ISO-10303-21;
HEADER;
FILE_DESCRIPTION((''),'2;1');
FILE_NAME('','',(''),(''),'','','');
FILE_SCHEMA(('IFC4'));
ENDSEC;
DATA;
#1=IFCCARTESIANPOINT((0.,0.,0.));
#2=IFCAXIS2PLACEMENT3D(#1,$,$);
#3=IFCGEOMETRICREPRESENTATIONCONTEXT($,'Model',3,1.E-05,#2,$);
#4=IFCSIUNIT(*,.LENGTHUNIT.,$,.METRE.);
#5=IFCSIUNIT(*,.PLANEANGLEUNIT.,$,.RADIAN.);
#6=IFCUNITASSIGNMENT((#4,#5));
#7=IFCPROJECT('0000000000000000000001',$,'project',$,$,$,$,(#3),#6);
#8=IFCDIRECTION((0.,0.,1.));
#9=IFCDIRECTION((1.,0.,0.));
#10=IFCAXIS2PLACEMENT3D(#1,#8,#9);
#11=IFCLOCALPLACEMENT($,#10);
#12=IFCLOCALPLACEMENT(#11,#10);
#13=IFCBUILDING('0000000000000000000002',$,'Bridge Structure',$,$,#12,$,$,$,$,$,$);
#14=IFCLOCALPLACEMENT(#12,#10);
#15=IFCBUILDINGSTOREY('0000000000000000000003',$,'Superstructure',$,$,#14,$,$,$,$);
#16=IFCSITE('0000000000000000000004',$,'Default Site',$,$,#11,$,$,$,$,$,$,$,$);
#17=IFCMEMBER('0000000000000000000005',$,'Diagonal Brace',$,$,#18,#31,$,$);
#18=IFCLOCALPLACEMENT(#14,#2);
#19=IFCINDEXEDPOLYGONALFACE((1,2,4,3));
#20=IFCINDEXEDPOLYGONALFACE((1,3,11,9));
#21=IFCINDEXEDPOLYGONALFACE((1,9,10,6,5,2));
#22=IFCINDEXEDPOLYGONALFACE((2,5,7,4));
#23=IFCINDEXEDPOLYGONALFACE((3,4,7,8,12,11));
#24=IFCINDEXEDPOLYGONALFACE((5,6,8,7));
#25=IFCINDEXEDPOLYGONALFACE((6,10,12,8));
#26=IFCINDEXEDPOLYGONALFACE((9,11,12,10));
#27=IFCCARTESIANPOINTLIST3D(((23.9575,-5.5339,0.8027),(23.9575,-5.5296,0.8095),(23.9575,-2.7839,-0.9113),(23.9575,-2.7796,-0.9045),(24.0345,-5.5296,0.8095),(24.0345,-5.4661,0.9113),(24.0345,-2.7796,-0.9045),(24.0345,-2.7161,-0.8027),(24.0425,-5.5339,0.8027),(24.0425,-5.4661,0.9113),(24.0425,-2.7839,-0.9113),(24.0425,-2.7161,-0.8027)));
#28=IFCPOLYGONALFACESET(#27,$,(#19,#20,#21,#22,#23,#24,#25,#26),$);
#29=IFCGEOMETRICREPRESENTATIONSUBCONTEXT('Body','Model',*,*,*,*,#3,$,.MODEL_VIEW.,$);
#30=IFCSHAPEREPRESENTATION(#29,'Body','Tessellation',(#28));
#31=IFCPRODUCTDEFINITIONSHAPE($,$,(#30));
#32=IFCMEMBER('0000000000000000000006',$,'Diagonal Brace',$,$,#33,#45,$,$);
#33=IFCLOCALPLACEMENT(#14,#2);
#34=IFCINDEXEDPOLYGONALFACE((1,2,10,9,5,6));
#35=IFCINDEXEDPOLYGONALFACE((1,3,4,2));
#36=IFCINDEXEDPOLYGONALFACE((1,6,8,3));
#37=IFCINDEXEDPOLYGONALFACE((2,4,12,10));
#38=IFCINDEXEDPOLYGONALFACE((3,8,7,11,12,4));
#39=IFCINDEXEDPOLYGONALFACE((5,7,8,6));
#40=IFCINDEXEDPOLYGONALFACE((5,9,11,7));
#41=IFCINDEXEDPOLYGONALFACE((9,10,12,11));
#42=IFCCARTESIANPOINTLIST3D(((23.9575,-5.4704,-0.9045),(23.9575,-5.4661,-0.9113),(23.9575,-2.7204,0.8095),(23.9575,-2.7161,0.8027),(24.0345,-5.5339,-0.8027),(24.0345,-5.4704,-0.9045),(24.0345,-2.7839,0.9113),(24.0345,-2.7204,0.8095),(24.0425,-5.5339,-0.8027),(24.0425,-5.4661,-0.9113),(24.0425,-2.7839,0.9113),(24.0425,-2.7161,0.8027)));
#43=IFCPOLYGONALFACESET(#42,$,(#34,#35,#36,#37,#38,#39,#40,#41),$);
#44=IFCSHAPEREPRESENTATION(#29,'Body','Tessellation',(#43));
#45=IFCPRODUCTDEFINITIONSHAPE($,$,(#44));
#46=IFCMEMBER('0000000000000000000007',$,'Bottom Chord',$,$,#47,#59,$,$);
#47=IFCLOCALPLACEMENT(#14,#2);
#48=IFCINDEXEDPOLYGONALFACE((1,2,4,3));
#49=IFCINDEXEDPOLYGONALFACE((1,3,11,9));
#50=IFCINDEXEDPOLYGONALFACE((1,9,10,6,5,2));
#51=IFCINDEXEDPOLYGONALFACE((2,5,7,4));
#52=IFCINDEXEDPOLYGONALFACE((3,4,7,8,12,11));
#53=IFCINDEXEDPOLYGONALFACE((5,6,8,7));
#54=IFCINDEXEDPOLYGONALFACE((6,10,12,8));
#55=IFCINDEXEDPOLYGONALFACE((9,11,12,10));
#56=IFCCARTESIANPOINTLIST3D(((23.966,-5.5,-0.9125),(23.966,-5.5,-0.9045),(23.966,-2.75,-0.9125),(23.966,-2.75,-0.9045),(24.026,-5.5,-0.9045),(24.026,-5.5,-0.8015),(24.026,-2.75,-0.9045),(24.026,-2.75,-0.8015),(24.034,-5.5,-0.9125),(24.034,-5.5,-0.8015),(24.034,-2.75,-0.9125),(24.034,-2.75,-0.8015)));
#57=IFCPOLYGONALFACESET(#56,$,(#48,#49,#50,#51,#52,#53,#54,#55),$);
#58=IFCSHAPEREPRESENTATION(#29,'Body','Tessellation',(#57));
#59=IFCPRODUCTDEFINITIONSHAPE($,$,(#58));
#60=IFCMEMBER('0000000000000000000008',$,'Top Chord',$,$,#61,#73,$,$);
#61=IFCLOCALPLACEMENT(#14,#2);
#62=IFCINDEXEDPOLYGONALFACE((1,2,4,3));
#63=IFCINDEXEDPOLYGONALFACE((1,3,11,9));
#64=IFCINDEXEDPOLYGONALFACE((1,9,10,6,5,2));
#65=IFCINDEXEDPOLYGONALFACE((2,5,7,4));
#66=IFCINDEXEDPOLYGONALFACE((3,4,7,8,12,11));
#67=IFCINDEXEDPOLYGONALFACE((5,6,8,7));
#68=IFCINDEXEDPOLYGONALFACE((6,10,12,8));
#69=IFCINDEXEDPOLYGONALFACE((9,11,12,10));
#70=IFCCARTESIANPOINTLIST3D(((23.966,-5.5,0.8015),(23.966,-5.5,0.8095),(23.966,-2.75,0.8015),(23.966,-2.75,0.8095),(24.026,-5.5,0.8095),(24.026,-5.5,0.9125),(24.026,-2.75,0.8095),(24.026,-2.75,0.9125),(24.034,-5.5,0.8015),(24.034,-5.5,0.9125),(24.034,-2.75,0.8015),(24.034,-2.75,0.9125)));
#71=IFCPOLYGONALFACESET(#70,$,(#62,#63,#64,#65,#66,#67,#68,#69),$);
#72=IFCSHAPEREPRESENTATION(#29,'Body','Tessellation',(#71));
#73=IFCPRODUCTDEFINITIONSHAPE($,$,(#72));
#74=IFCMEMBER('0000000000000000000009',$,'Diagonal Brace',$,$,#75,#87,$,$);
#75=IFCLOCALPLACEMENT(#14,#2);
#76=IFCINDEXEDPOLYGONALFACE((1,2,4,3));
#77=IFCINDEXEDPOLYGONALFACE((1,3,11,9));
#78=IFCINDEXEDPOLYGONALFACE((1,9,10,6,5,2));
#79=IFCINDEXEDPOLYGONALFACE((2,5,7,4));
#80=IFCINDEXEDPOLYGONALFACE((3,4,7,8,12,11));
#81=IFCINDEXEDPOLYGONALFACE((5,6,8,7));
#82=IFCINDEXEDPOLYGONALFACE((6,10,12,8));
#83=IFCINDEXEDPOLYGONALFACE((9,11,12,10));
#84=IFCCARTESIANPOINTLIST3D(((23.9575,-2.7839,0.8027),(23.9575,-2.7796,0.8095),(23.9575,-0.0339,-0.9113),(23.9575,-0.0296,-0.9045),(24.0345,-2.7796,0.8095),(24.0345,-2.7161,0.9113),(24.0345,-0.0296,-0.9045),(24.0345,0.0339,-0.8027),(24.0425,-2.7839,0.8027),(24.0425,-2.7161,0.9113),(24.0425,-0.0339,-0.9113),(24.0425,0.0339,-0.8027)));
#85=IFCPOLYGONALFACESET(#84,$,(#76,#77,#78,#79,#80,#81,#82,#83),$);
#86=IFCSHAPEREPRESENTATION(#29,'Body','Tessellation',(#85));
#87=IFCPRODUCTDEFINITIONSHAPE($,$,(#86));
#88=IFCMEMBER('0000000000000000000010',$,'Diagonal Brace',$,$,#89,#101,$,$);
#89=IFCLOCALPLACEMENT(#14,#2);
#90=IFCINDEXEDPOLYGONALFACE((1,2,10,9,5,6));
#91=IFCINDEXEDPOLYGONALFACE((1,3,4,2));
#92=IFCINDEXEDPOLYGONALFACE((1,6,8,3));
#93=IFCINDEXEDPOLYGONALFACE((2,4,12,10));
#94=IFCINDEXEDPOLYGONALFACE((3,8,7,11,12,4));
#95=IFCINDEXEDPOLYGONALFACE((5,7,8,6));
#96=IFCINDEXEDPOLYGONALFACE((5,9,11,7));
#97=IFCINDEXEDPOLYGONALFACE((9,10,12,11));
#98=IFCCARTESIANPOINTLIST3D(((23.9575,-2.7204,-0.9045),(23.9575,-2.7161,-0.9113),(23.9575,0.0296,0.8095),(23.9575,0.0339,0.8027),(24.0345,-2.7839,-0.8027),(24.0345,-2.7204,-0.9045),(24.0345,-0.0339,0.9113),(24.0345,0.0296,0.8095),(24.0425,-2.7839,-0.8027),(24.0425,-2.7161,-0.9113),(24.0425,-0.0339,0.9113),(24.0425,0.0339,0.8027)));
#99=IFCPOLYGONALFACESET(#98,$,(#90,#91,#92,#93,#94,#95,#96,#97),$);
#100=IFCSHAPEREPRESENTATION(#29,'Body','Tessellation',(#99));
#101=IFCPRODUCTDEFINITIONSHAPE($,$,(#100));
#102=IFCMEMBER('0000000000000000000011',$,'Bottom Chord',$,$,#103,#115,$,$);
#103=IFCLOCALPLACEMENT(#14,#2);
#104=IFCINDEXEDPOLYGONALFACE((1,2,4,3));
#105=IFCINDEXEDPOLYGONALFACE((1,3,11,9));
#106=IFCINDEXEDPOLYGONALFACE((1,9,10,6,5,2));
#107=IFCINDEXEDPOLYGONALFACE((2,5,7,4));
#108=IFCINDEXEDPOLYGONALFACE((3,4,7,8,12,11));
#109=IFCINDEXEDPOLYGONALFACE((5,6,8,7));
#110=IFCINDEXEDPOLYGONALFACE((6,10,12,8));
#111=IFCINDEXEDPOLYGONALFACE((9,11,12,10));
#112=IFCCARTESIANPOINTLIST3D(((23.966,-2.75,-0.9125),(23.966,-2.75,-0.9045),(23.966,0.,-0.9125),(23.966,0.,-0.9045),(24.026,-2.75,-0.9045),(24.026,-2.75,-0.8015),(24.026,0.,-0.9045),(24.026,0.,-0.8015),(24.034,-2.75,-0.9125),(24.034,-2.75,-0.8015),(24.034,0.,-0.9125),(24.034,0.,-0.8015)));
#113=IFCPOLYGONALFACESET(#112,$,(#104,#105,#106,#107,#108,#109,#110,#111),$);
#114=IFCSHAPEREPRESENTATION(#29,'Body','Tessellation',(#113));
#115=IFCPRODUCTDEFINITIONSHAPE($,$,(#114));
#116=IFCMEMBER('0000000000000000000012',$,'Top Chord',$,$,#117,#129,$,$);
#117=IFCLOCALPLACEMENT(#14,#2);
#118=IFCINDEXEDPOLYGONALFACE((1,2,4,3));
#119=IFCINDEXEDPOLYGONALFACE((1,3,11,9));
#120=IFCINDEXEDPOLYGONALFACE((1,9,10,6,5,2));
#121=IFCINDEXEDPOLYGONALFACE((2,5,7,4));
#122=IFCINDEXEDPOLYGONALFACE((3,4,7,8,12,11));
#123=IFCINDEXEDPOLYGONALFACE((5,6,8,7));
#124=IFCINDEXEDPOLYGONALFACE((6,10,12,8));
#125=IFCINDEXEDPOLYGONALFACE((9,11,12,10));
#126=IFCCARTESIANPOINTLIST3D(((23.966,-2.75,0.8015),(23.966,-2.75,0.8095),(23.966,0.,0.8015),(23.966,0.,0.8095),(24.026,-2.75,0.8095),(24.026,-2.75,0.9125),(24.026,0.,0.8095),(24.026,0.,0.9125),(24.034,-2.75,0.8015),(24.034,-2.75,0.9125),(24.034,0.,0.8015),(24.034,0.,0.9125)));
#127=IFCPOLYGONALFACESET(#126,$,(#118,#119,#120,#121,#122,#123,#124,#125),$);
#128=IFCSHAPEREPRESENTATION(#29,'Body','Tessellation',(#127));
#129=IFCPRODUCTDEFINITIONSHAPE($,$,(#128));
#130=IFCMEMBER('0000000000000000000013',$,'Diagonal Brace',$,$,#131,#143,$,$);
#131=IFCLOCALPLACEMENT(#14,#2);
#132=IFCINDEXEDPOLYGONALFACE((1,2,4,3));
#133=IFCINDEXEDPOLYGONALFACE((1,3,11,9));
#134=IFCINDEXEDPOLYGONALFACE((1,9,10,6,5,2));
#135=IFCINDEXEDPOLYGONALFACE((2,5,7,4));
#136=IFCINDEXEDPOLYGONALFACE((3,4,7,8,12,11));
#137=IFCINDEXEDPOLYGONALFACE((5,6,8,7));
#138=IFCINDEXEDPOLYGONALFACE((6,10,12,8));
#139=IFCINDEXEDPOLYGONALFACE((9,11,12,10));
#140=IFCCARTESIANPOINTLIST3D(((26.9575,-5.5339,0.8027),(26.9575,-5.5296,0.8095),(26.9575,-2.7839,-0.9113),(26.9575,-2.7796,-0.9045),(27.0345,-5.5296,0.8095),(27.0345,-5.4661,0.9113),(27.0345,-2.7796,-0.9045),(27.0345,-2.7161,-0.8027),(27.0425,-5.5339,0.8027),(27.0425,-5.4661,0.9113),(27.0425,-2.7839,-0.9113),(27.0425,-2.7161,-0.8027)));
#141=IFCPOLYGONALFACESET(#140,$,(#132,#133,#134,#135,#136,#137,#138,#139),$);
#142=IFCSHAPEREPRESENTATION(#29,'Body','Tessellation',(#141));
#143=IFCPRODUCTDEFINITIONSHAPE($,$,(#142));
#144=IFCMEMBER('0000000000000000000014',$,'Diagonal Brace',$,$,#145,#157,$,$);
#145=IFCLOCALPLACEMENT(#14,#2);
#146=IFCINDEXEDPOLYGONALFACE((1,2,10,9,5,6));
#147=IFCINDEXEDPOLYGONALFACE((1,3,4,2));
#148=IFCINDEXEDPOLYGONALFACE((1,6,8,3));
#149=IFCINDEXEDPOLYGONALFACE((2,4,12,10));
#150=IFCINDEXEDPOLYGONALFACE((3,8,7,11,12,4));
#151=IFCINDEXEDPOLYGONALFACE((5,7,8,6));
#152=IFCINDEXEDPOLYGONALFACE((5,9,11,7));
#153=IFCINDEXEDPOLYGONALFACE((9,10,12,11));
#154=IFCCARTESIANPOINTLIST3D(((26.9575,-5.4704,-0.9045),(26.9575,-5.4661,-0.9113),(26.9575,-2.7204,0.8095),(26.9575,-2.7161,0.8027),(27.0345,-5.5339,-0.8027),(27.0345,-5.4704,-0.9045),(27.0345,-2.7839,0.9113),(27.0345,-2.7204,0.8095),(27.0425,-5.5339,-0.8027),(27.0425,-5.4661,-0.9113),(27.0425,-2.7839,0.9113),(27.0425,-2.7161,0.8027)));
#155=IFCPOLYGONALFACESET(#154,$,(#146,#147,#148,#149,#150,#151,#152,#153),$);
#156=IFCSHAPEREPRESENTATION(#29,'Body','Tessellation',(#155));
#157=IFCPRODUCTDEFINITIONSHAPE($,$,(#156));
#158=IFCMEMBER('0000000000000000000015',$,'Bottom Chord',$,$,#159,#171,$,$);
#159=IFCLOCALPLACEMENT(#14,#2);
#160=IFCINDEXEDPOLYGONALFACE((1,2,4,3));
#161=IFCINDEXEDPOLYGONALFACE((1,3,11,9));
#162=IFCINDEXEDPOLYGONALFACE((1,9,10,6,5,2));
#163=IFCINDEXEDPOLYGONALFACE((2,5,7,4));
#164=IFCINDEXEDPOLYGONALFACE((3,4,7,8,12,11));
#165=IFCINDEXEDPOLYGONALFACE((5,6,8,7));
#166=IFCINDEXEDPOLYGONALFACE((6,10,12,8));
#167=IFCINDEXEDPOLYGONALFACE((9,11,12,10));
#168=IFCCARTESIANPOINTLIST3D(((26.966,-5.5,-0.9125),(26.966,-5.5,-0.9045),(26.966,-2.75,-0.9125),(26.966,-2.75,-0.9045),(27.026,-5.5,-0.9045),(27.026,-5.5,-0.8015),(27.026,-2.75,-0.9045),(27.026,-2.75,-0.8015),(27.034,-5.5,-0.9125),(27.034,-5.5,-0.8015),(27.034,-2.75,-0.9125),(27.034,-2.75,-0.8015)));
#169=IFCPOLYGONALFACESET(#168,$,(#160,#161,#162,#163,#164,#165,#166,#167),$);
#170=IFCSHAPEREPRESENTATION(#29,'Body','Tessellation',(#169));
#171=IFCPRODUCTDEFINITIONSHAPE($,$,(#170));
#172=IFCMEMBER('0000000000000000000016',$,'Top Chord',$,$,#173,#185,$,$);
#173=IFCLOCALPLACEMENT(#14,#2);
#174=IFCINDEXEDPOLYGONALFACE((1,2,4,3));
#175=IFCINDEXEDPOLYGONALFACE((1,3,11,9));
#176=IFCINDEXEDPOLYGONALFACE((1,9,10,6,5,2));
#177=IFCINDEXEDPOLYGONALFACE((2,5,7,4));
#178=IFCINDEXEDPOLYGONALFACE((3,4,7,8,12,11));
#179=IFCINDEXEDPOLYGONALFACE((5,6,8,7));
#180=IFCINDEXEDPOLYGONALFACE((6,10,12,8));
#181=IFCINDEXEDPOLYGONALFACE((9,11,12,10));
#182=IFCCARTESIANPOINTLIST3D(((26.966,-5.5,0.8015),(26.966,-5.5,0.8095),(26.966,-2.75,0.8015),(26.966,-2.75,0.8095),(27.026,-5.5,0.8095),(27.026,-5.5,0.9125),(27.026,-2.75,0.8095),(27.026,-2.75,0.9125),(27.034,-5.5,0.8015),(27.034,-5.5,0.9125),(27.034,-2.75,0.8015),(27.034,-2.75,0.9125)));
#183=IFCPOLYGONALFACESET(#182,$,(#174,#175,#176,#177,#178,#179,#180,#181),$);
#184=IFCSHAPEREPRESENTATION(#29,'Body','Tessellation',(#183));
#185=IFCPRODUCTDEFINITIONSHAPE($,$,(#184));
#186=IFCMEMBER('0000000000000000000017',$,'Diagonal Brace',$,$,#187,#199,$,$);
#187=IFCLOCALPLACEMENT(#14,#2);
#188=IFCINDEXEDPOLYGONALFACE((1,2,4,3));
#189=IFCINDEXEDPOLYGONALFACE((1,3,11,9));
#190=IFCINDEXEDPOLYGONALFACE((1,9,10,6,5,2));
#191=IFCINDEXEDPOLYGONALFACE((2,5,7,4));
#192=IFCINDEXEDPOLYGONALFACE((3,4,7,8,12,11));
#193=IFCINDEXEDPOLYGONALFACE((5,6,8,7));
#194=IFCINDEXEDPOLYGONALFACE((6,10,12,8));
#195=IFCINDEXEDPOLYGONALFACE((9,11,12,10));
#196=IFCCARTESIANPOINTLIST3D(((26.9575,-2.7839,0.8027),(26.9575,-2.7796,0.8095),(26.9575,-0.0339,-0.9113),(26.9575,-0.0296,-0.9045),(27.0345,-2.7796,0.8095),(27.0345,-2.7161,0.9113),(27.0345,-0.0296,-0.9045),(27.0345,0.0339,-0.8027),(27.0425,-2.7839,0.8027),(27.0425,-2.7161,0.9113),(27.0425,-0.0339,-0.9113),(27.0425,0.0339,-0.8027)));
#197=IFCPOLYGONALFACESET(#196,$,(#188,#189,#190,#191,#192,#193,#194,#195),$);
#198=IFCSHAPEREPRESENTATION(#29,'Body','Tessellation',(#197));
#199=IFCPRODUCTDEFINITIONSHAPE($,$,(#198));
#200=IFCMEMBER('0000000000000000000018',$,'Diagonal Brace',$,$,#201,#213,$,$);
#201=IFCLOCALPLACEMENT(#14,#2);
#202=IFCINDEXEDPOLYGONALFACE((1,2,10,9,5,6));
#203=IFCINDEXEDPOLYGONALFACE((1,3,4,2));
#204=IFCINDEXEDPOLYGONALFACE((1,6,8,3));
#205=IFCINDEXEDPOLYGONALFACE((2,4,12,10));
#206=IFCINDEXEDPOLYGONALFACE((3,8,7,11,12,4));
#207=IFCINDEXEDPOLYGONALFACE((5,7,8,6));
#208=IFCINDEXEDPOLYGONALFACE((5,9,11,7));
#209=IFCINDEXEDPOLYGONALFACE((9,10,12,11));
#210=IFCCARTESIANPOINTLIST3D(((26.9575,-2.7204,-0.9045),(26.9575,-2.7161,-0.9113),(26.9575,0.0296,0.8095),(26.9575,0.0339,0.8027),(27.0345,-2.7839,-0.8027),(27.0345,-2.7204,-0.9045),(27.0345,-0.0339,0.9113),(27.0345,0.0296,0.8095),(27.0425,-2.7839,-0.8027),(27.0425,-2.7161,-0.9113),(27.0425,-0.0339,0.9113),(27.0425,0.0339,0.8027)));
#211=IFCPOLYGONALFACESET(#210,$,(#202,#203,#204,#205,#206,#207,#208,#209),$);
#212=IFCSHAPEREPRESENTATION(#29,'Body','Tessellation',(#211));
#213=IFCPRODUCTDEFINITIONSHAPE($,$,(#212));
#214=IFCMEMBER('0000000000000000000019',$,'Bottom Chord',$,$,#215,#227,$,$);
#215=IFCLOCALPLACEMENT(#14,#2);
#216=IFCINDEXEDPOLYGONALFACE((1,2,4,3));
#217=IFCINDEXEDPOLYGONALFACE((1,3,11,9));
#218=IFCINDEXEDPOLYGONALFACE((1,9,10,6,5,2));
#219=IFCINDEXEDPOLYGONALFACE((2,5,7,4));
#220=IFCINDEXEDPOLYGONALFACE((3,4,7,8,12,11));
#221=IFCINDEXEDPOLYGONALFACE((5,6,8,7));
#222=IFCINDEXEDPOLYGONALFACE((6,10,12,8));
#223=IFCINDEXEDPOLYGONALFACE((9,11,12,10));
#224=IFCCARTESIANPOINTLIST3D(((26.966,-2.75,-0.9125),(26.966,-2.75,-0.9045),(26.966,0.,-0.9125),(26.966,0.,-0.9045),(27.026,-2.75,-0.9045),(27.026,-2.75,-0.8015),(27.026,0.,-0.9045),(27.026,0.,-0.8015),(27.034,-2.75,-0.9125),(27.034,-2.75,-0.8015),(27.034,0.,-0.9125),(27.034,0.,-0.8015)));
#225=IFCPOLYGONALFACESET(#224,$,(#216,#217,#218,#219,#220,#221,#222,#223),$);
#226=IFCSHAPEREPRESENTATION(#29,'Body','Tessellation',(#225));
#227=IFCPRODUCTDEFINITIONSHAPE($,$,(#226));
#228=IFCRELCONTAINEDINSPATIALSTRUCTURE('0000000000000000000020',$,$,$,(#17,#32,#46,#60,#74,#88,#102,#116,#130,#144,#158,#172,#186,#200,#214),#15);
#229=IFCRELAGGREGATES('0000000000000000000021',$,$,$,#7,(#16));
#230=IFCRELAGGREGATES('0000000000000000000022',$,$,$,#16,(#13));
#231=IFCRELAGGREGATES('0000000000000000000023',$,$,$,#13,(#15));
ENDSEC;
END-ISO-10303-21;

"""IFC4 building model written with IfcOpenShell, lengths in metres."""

from ifc_helpers import new_model, si_unit, frame, origin, origin_with_axes, origin_2d_with_axis, place, context, subcontext, project, spatial, l_section, extrude, element, save


model = new_model("IFC4")

# Units and contexts
model_context = context("Model", 3, precision=1e-05, world=origin())
body_context = subcontext(model_context, "Body", "Model", "MODEL_VIEW")
ifc_project = project(units=[si_unit("LENGTHUNIT", "METRE"), si_unit("PLANEANGLEUNIT", "RADIAN")], contexts=[model_context])

# Site, building, storey
site_placement = place(None, origin_with_axes())
site = spatial("IfcSite", under=ifc_project, at=site_placement, Name="Default Site")
building_placement = place(site_placement, origin_with_axes())
building = spatial("IfcBuilding", under=site, at=building_placement, Name="Bridge Structure")
storey_placement = place(building_placement, origin_with_axes())
storey = spatial("IfcBuildingStorey", under=building, at=storey_placement, Name="Superstructure")

# Members
for number, where, z_axis, x_axis, name in (
    (1, (24.0, -5.5, 0.857), (0.0, 0.848656, -0.528944), (-1.0, 0.0, 0.0), "Diagonal Brace"),
    (2, (24.0, -5.5, -0.857), (0.0, 0.848656, 0.528944), (-1.0, 0.0, 0.0), "Diagonal Brace"),
):
    element("IfcMember", number, at=place(storey_placement, frame(where, z_axis=z_axis, x_axis=x_axis)), inside=storey, Name=name, context=body_context, shape_type="SweptSolid", body=[
        extrude(l_section(Depth=0.128, Width=0.085, Thickness=0.008, at=origin_2d_with_axis()), origin_with_axes(), (0.0, 0.0, 1.0), 3.2404),
    ])
for number, where, z_axis, x_axis, name in (
    (3, (24.0, -5.5, -0.857), (0.0, 1.0, 0.0), (-1.0, 0.0, 0.0), "Bottom Chord"),
    (4, (24.0, -5.5, 0.857), (0.0, 1.0, 0.0), (-1.0, 0.0, 0.0), "Top Chord"),
):
    element("IfcMember", number, at=place(storey_placement, frame(where, z_axis=z_axis, x_axis=x_axis)), inside=storey, Name=name, context=body_context, shape_type="SweptSolid", body=[
        extrude(l_section(Depth=0.111, Width=0.068, Thickness=0.008, at=origin_2d_with_axis()), origin_with_axes(), (0.0, 0.0, 1.0), 2.75),
    ])
for number, where, z_axis, x_axis, name in (
    (5, (24.0, -2.75, 0.857), (0.0, 0.848656, -0.528944), (-1.0, 0.0, 0.0), "Diagonal Brace"),
    (6, (24.0, -2.75, -0.857), (0.0, 0.848656, 0.528944), (-1.0, 0.0, 0.0), "Diagonal Brace"),
):
    element("IfcMember", number, at=place(storey_placement, frame(where, z_axis=z_axis, x_axis=x_axis)), inside=storey, Name=name, context=body_context, shape_type="SweptSolid", body=[
        extrude(l_section(Depth=0.128, Width=0.085, Thickness=0.008, at=origin_2d_with_axis()), origin_with_axes(), (0.0, 0.0, 1.0), 3.2404),
    ])
for number, where, z_axis, x_axis, name in (
    (7, (24.0, -2.75, -0.857), (0.0, 1.0, 0.0), (-1.0, 0.0, 0.0), "Bottom Chord"),
    (8, (24.0, -2.75, 0.857), (0.0, 1.0, 0.0), (-1.0, 0.0, 0.0), "Top Chord"),
):
    element("IfcMember", number, at=place(storey_placement, frame(where, z_axis=z_axis, x_axis=x_axis)), inside=storey, Name=name, context=body_context, shape_type="SweptSolid", body=[
        extrude(l_section(Depth=0.111, Width=0.068, Thickness=0.008, at=origin_2d_with_axis()), origin_with_axes(), (0.0, 0.0, 1.0), 2.75),
    ])
for number, where, z_axis, x_axis, name in (
    (9, (27.0, -5.5, 0.857), (0.0, 0.848656, -0.528944), (-1.0, 0.0, 0.0), "Diagonal Brace"),
    (10, (27.0, -5.5, -0.857), (0.0, 0.848656, 0.528944), (-1.0, 0.0, 0.0), "Diagonal Brace"),
):
    element("IfcMember", number, at=place(storey_placement, frame(where, z_axis=z_axis, x_axis=x_axis)), inside=storey, Name=name, context=body_context, shape_type="SweptSolid", body=[
        extrude(l_section(Depth=0.128, Width=0.085, Thickness=0.008, at=origin_2d_with_axis()), origin_with_axes(), (0.0, 0.0, 1.0), 3.2404),
    ])
for number, where, z_axis, x_axis, name in (
    (11, (27.0, -5.5, -0.857), (0.0, 1.0, 0.0), (-1.0, 0.0, 0.0), "Bottom Chord"),
    (12, (27.0, -5.5, 0.857), (0.0, 1.0, 0.0), (-1.0, 0.0, 0.0), "Top Chord"),
):
    element("IfcMember", number, at=place(storey_placement, frame(where, z_axis=z_axis, x_axis=x_axis)), inside=storey, Name=name, context=body_context, shape_type="SweptSolid", body=[
        extrude(l_section(Depth=0.111, Width=0.068, Thickness=0.008, at=origin_2d_with_axis()), origin_with_axes(), (0.0, 0.0, 1.0), 2.75),
    ])
for number, where, z_axis, x_axis, name in (
    (13, (27.0, -2.75, 0.857), (0.0, 0.848656, -0.528944), (-1.0, 0.0, 0.0), "Diagonal Brace"),
    (14, (27.0, -2.75, -0.857), (0.0, 0.848656, 0.528944), (-1.0, 0.0, 0.0), "Diagonal Brace"),
):
    element("IfcMember", number, at=place(storey_placement, frame(where, z_axis=z_axis, x_axis=x_axis)), inside=storey, Name=name, context=body_context, shape_type="SweptSolid", body=[
        extrude(l_section(Depth=0.128, Width=0.085, Thickness=0.008, at=origin_2d_with_axis()), origin_with_axes(), (0.0, 0.0, 1.0), 3.2404),
    ])
for number, where, z_axis, x_axis, name in (
    (15, (27.0, -2.75, -0.857), (0.0, 1.0, 0.0), (-1.0, 0.0, 0.0), "Bottom Chord"),
):
    element("IfcMember", number, at=place(storey_placement, frame(where, z_axis=z_axis, x_axis=x_axis)), inside=storey, Name=name, context=body_context, shape_type="SweptSolid", body=[
        extrude(l_section(Depth=0.111, Width=0.068, Thickness=0.008, at=origin_2d_with_axis()), origin_with_axes(), (0.0, 0.0, 1.0), 2.75),
    ])

save(model, "model.ifc")
